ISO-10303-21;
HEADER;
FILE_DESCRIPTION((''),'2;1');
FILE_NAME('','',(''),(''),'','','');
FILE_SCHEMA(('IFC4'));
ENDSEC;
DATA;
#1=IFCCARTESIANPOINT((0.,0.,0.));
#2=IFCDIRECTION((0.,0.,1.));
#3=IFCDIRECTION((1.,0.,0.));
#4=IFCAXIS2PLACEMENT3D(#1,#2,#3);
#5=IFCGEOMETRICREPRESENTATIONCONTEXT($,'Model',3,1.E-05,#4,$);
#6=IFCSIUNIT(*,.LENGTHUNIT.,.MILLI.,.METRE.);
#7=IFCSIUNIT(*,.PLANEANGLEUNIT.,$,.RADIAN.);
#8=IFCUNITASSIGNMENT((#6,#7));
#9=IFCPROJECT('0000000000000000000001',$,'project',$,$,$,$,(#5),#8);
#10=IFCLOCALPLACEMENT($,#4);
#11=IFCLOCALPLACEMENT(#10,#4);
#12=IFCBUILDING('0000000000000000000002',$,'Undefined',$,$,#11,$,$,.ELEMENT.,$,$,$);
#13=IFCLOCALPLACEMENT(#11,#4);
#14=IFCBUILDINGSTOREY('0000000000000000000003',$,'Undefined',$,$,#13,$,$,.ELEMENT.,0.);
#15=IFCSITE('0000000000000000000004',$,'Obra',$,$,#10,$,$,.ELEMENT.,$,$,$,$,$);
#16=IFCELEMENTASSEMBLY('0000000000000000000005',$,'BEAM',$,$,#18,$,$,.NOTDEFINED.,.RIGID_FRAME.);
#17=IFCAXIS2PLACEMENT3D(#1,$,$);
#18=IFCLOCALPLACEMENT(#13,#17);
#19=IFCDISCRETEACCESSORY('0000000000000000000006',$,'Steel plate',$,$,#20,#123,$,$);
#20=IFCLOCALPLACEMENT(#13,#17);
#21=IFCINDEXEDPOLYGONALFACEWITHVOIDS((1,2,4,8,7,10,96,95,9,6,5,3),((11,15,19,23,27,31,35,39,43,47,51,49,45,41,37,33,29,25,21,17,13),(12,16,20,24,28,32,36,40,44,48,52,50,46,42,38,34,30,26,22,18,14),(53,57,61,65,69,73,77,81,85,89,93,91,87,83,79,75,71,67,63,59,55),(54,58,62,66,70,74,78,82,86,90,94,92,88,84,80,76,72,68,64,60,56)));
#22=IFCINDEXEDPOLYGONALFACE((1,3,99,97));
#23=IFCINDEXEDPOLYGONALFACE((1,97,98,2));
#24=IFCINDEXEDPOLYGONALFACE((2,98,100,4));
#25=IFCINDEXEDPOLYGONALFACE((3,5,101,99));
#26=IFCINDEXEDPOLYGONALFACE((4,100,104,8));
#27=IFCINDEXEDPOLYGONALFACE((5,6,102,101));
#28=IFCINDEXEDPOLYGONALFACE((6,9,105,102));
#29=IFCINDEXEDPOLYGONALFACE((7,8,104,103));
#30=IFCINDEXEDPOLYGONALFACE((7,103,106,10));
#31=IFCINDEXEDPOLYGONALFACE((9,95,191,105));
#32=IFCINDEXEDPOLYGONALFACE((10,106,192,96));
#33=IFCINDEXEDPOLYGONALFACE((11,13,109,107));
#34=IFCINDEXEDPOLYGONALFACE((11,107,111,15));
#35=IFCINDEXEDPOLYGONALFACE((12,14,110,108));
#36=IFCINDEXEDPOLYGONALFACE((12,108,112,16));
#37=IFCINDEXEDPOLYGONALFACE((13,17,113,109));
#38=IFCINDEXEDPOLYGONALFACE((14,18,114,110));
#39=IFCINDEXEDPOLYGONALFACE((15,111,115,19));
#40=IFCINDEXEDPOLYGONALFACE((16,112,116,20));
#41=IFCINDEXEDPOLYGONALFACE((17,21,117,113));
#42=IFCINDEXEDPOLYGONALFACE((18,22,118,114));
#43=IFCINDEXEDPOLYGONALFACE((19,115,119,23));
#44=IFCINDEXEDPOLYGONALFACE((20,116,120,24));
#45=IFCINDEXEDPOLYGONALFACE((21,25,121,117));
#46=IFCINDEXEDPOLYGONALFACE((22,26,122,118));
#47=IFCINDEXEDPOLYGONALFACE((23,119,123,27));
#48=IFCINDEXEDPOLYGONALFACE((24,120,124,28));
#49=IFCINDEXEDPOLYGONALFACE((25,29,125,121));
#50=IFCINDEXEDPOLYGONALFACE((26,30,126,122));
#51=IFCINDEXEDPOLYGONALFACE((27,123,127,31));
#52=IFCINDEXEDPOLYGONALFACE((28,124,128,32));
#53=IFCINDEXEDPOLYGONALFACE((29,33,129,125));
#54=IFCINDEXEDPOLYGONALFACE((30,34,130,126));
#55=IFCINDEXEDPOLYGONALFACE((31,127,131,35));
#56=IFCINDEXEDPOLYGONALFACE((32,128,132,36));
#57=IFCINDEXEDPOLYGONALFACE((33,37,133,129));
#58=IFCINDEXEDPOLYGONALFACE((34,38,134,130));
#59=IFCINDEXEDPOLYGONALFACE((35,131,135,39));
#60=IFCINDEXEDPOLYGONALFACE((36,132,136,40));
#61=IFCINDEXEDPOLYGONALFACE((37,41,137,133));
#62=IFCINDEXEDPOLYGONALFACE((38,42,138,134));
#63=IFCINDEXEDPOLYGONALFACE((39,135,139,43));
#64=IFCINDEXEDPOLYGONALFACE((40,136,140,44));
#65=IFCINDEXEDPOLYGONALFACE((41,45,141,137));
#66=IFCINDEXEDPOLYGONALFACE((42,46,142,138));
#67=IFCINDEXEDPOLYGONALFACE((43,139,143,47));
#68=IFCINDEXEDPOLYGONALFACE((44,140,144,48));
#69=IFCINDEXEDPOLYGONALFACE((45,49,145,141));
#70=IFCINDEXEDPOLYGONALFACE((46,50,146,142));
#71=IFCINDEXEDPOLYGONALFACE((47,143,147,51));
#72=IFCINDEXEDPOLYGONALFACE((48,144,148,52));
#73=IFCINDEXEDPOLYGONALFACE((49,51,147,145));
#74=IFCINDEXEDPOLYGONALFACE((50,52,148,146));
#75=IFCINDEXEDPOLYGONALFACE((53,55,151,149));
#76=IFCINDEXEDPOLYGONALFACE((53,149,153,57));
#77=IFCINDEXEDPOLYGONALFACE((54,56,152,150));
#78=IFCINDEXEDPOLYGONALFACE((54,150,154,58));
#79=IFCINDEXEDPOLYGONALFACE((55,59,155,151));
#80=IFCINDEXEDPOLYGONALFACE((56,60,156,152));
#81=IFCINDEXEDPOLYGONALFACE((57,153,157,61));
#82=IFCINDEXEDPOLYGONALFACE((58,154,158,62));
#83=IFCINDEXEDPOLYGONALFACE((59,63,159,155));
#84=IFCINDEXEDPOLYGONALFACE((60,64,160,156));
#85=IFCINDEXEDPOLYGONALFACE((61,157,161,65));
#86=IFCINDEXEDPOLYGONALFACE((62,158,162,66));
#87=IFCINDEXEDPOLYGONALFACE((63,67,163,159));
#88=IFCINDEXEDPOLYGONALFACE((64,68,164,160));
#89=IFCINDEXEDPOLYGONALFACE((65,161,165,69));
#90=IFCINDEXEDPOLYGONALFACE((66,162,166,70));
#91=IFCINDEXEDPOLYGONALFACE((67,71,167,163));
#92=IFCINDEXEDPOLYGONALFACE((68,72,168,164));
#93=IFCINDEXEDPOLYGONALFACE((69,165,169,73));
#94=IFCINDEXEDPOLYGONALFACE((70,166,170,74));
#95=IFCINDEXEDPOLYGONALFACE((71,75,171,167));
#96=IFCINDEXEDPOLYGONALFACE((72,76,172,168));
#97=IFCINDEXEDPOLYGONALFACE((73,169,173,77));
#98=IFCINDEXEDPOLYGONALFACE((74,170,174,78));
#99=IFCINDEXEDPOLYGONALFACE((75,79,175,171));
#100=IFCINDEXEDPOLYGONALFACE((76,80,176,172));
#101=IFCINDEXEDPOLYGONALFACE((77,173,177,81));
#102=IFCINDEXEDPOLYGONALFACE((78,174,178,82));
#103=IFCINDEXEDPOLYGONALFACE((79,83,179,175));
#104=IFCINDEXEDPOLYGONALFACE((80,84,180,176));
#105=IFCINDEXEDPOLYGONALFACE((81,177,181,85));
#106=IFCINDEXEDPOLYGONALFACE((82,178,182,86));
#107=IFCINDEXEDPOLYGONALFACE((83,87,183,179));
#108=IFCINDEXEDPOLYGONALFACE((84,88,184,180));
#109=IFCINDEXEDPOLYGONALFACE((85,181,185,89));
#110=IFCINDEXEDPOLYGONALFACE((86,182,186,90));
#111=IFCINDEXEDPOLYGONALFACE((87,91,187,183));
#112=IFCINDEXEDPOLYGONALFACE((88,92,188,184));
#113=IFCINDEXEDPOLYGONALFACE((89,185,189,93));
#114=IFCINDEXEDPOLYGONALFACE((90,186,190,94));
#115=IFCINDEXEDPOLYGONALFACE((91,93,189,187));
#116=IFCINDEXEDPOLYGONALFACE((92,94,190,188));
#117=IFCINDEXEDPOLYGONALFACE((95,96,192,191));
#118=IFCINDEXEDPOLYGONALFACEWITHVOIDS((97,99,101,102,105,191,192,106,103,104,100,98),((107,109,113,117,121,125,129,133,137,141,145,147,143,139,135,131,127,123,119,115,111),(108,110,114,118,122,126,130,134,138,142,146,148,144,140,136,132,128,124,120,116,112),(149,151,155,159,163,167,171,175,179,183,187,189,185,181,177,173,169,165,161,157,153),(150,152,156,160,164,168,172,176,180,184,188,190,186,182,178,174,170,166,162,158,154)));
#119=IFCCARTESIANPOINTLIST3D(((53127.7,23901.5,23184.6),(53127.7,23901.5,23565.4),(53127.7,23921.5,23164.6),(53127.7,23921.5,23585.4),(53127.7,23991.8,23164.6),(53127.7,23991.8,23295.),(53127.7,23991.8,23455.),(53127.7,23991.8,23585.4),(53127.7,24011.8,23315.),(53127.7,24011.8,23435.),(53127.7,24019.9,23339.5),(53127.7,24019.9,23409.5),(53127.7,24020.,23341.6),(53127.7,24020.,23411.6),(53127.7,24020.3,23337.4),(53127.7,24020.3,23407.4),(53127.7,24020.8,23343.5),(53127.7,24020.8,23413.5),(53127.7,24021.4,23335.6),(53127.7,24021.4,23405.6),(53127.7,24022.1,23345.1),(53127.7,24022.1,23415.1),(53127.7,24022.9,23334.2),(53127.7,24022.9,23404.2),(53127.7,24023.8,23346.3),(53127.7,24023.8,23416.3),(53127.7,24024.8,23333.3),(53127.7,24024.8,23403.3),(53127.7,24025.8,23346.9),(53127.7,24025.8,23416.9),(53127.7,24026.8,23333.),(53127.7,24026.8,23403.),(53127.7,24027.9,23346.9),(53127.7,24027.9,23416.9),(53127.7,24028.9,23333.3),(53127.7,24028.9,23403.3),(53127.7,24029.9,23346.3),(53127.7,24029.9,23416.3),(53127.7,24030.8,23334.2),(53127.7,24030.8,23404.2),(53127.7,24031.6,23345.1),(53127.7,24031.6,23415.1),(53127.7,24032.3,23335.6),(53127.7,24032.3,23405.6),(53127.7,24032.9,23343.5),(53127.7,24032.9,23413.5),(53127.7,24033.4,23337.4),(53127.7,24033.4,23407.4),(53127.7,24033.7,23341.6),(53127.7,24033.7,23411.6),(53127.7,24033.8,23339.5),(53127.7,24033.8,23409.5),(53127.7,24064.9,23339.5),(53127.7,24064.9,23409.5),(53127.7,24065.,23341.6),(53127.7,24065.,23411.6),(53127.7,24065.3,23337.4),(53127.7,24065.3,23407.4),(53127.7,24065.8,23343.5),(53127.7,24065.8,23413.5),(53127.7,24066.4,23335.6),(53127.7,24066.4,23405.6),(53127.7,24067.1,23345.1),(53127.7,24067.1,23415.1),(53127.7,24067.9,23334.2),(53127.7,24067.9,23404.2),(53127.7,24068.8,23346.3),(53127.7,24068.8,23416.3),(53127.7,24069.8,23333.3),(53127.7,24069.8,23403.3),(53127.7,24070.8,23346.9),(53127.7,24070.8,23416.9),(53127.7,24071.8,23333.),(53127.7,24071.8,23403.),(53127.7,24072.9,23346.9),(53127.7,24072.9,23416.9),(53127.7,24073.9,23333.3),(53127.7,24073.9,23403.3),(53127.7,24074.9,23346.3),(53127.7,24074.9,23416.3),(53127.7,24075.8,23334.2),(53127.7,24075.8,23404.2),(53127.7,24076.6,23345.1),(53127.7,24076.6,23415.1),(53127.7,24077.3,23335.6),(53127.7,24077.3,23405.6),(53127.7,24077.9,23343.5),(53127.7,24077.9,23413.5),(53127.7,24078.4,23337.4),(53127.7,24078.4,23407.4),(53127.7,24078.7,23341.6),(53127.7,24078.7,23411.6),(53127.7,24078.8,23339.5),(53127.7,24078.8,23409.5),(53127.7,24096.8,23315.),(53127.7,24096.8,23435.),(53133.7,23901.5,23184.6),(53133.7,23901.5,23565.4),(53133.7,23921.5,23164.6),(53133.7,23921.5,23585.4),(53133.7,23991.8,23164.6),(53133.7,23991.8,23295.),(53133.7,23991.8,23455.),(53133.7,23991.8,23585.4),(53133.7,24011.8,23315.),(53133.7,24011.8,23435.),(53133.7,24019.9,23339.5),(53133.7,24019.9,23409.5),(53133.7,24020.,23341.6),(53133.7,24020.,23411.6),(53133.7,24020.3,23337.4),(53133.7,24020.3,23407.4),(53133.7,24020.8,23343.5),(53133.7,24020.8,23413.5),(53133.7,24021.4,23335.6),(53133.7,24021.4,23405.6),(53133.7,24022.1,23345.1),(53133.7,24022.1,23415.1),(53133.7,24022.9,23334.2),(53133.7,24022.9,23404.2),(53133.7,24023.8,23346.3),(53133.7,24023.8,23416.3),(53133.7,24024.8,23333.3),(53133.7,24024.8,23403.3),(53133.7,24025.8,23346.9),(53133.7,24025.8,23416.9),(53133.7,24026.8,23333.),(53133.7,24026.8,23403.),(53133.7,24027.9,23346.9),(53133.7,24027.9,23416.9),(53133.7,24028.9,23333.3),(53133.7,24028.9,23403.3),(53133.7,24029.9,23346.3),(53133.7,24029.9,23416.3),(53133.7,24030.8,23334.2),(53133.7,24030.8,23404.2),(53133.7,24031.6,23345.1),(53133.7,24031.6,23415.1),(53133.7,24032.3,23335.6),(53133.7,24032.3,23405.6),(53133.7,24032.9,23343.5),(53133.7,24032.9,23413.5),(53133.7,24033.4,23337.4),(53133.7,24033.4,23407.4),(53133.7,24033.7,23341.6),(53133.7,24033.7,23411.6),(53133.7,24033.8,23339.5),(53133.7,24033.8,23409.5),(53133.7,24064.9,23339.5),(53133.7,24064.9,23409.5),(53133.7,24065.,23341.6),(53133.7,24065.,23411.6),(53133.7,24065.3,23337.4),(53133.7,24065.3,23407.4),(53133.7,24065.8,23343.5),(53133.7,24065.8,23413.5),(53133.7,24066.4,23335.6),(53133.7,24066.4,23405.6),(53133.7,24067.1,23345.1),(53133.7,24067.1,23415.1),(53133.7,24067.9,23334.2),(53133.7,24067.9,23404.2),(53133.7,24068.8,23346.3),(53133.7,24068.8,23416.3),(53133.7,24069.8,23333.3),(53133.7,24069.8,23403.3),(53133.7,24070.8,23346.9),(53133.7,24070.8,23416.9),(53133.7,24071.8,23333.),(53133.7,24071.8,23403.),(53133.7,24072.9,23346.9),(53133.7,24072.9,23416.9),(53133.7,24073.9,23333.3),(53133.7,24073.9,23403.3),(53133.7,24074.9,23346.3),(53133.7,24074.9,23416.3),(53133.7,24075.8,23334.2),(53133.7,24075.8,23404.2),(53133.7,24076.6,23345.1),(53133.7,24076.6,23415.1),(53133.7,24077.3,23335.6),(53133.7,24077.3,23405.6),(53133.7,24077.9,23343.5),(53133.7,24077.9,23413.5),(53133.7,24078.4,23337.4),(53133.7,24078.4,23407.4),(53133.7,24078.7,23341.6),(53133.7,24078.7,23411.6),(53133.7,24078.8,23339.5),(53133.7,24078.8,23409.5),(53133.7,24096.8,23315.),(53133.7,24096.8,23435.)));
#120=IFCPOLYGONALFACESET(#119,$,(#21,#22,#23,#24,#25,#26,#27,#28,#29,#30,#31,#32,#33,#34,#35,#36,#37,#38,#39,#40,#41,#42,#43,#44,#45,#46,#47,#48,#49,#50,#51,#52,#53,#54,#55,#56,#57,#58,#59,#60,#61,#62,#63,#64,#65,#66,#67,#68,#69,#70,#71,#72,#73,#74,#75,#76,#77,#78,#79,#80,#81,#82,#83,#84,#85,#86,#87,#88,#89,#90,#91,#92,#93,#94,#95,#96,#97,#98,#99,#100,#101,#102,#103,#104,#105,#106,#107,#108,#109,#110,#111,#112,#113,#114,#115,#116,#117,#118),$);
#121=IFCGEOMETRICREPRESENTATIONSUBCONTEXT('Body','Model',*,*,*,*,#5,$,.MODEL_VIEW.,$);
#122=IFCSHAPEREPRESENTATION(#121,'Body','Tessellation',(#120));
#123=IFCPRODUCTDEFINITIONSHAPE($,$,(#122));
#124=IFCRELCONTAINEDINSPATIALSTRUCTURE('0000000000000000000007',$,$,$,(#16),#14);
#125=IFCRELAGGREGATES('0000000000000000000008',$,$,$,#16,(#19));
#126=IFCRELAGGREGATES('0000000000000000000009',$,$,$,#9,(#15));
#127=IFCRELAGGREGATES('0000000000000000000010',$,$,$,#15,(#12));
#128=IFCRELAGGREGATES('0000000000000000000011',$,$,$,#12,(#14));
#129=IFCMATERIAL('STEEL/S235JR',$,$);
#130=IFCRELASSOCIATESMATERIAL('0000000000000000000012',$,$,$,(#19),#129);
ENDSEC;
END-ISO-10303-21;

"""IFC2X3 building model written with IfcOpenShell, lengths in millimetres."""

from ifc_helpers import new_model, si_unit, frame, origin_with_axes, origin_2d_with_axis, place, context, subcontext, project, spatial, polyline, circle, outline, extrude, source, transform, mapped, material, element, aggregate, save


model = new_model("IFC2X3")

# Units and contexts
model_context = context("Model", 3, precision=1e-05, world=origin_with_axes())
body_context = subcontext(model_context, "Body", "Model", "MODEL_VIEW")
ifc_project = project(units=[si_unit("LENGTHUNIT", "METRE", prefix="MILLI"), si_unit("PLANEANGLEUNIT", "RADIAN")], contexts=[model_context])

# Site, building, storey
site_placement = place(None, origin_with_axes())
site = spatial("IfcSite", under=ifc_project, at=site_placement, Name="Obra", CompositionType="ELEMENT")
building_placement = place(site_placement, origin_with_axes())
building = spatial("IfcBuilding", under=site, at=building_placement, Name="Undefined", CompositionType="ELEMENT")
storey_placement = place(building_placement, origin_with_axes())
storey = spatial("IfcBuildingStorey", under=building, at=storey_placement, Name="Undefined", CompositionType="ELEMENT", Elevation=0.0)

# Shared definitions
ifc_material_1 = material(Name="STEEL/S235JR")

# Element assembly
assembly_1_placement = place(storey_placement, origin_with_axes())
assembly_1 = element("IfcElementAssembly", 1, at=assembly_1_placement, inside=storey, Name="BEAM", AssemblyPlace="NOTDEFINED", PredefinedType="RIGID_FRAME")
shared_shape_1 = source(origin_with_axes(), body_context, "Body", "SweptSolid", [
    extrude(circle(Radius=7.0, at=origin_2d_with_axis()), frame((0.0, -8.6, 0.0), z_axis=(0.0, 1.0, 0.0), x_axis=(1.0, 0.0, 0.0)), (0.0, 0.0, 1.0), 6.2),
])

# Discrete accessory, opening
discrete_accessory_1_placement = place(assembly_1_placement, frame((53130.7, 23901.5, 23184.6), z_axis=(1.0, 0.0, 0.0), x_axis=(-0.000001, 0.707107, -0.707107)))
discrete_accessory_1 = element("IfcDiscreteAccessory", 2, at=discrete_accessory_1_placement, material=ifc_material_1, Name="Steel plate", context=body_context, shape_type="SweptSolid", body=[
    extrude(outline(polyline([(0.0, 0.0), (28.3, 0.0), (78.0, 49.7), (-14.2, 141.9), (-14.2, 170.2), (45.9, 230.3), (-39.0, 315.2), (-99.1, 255.1), (-127.3, 255.1), (-219.6, 347.3), (-269.3, 297.6), (-269.3, 269.3), (0.0, 0.0)])), frame((0.0, 0.0, -3.0), z_axis=(0.0, 0.0, 1.0), x_axis=(1.0, 0.0, 0.0)), (0.0, 0.0, 1.0), 6.0),
])
opening_1_placement = place(assembly_1_placement, frame((53125.2, 24001.8, 23435.0), z_axis=(0.0, 1.0, 0.0), x_axis=(0.0, 0.0, -1.0)))
element("IfcOpeningElement", 3, at=opening_1_placement, cuts=discrete_accessory_1, ObjectType="Opening", context=body_context, shape_type="MappedRepresentation", body=[
    mapped(shared_shape_1, transform((25.0, 0.0, 25.0))),
    mapped(shared_shape_1, transform((25.0, 0.0, 70.0))),
    mapped(shared_shape_1, transform((95.0, 0.0, 25.0))),
    mapped(shared_shape_1, transform((95.0, 0.0, 70.0))),
])
aggregate(assembly_1, [discrete_accessory_1])

save(model, "model.ifc")
